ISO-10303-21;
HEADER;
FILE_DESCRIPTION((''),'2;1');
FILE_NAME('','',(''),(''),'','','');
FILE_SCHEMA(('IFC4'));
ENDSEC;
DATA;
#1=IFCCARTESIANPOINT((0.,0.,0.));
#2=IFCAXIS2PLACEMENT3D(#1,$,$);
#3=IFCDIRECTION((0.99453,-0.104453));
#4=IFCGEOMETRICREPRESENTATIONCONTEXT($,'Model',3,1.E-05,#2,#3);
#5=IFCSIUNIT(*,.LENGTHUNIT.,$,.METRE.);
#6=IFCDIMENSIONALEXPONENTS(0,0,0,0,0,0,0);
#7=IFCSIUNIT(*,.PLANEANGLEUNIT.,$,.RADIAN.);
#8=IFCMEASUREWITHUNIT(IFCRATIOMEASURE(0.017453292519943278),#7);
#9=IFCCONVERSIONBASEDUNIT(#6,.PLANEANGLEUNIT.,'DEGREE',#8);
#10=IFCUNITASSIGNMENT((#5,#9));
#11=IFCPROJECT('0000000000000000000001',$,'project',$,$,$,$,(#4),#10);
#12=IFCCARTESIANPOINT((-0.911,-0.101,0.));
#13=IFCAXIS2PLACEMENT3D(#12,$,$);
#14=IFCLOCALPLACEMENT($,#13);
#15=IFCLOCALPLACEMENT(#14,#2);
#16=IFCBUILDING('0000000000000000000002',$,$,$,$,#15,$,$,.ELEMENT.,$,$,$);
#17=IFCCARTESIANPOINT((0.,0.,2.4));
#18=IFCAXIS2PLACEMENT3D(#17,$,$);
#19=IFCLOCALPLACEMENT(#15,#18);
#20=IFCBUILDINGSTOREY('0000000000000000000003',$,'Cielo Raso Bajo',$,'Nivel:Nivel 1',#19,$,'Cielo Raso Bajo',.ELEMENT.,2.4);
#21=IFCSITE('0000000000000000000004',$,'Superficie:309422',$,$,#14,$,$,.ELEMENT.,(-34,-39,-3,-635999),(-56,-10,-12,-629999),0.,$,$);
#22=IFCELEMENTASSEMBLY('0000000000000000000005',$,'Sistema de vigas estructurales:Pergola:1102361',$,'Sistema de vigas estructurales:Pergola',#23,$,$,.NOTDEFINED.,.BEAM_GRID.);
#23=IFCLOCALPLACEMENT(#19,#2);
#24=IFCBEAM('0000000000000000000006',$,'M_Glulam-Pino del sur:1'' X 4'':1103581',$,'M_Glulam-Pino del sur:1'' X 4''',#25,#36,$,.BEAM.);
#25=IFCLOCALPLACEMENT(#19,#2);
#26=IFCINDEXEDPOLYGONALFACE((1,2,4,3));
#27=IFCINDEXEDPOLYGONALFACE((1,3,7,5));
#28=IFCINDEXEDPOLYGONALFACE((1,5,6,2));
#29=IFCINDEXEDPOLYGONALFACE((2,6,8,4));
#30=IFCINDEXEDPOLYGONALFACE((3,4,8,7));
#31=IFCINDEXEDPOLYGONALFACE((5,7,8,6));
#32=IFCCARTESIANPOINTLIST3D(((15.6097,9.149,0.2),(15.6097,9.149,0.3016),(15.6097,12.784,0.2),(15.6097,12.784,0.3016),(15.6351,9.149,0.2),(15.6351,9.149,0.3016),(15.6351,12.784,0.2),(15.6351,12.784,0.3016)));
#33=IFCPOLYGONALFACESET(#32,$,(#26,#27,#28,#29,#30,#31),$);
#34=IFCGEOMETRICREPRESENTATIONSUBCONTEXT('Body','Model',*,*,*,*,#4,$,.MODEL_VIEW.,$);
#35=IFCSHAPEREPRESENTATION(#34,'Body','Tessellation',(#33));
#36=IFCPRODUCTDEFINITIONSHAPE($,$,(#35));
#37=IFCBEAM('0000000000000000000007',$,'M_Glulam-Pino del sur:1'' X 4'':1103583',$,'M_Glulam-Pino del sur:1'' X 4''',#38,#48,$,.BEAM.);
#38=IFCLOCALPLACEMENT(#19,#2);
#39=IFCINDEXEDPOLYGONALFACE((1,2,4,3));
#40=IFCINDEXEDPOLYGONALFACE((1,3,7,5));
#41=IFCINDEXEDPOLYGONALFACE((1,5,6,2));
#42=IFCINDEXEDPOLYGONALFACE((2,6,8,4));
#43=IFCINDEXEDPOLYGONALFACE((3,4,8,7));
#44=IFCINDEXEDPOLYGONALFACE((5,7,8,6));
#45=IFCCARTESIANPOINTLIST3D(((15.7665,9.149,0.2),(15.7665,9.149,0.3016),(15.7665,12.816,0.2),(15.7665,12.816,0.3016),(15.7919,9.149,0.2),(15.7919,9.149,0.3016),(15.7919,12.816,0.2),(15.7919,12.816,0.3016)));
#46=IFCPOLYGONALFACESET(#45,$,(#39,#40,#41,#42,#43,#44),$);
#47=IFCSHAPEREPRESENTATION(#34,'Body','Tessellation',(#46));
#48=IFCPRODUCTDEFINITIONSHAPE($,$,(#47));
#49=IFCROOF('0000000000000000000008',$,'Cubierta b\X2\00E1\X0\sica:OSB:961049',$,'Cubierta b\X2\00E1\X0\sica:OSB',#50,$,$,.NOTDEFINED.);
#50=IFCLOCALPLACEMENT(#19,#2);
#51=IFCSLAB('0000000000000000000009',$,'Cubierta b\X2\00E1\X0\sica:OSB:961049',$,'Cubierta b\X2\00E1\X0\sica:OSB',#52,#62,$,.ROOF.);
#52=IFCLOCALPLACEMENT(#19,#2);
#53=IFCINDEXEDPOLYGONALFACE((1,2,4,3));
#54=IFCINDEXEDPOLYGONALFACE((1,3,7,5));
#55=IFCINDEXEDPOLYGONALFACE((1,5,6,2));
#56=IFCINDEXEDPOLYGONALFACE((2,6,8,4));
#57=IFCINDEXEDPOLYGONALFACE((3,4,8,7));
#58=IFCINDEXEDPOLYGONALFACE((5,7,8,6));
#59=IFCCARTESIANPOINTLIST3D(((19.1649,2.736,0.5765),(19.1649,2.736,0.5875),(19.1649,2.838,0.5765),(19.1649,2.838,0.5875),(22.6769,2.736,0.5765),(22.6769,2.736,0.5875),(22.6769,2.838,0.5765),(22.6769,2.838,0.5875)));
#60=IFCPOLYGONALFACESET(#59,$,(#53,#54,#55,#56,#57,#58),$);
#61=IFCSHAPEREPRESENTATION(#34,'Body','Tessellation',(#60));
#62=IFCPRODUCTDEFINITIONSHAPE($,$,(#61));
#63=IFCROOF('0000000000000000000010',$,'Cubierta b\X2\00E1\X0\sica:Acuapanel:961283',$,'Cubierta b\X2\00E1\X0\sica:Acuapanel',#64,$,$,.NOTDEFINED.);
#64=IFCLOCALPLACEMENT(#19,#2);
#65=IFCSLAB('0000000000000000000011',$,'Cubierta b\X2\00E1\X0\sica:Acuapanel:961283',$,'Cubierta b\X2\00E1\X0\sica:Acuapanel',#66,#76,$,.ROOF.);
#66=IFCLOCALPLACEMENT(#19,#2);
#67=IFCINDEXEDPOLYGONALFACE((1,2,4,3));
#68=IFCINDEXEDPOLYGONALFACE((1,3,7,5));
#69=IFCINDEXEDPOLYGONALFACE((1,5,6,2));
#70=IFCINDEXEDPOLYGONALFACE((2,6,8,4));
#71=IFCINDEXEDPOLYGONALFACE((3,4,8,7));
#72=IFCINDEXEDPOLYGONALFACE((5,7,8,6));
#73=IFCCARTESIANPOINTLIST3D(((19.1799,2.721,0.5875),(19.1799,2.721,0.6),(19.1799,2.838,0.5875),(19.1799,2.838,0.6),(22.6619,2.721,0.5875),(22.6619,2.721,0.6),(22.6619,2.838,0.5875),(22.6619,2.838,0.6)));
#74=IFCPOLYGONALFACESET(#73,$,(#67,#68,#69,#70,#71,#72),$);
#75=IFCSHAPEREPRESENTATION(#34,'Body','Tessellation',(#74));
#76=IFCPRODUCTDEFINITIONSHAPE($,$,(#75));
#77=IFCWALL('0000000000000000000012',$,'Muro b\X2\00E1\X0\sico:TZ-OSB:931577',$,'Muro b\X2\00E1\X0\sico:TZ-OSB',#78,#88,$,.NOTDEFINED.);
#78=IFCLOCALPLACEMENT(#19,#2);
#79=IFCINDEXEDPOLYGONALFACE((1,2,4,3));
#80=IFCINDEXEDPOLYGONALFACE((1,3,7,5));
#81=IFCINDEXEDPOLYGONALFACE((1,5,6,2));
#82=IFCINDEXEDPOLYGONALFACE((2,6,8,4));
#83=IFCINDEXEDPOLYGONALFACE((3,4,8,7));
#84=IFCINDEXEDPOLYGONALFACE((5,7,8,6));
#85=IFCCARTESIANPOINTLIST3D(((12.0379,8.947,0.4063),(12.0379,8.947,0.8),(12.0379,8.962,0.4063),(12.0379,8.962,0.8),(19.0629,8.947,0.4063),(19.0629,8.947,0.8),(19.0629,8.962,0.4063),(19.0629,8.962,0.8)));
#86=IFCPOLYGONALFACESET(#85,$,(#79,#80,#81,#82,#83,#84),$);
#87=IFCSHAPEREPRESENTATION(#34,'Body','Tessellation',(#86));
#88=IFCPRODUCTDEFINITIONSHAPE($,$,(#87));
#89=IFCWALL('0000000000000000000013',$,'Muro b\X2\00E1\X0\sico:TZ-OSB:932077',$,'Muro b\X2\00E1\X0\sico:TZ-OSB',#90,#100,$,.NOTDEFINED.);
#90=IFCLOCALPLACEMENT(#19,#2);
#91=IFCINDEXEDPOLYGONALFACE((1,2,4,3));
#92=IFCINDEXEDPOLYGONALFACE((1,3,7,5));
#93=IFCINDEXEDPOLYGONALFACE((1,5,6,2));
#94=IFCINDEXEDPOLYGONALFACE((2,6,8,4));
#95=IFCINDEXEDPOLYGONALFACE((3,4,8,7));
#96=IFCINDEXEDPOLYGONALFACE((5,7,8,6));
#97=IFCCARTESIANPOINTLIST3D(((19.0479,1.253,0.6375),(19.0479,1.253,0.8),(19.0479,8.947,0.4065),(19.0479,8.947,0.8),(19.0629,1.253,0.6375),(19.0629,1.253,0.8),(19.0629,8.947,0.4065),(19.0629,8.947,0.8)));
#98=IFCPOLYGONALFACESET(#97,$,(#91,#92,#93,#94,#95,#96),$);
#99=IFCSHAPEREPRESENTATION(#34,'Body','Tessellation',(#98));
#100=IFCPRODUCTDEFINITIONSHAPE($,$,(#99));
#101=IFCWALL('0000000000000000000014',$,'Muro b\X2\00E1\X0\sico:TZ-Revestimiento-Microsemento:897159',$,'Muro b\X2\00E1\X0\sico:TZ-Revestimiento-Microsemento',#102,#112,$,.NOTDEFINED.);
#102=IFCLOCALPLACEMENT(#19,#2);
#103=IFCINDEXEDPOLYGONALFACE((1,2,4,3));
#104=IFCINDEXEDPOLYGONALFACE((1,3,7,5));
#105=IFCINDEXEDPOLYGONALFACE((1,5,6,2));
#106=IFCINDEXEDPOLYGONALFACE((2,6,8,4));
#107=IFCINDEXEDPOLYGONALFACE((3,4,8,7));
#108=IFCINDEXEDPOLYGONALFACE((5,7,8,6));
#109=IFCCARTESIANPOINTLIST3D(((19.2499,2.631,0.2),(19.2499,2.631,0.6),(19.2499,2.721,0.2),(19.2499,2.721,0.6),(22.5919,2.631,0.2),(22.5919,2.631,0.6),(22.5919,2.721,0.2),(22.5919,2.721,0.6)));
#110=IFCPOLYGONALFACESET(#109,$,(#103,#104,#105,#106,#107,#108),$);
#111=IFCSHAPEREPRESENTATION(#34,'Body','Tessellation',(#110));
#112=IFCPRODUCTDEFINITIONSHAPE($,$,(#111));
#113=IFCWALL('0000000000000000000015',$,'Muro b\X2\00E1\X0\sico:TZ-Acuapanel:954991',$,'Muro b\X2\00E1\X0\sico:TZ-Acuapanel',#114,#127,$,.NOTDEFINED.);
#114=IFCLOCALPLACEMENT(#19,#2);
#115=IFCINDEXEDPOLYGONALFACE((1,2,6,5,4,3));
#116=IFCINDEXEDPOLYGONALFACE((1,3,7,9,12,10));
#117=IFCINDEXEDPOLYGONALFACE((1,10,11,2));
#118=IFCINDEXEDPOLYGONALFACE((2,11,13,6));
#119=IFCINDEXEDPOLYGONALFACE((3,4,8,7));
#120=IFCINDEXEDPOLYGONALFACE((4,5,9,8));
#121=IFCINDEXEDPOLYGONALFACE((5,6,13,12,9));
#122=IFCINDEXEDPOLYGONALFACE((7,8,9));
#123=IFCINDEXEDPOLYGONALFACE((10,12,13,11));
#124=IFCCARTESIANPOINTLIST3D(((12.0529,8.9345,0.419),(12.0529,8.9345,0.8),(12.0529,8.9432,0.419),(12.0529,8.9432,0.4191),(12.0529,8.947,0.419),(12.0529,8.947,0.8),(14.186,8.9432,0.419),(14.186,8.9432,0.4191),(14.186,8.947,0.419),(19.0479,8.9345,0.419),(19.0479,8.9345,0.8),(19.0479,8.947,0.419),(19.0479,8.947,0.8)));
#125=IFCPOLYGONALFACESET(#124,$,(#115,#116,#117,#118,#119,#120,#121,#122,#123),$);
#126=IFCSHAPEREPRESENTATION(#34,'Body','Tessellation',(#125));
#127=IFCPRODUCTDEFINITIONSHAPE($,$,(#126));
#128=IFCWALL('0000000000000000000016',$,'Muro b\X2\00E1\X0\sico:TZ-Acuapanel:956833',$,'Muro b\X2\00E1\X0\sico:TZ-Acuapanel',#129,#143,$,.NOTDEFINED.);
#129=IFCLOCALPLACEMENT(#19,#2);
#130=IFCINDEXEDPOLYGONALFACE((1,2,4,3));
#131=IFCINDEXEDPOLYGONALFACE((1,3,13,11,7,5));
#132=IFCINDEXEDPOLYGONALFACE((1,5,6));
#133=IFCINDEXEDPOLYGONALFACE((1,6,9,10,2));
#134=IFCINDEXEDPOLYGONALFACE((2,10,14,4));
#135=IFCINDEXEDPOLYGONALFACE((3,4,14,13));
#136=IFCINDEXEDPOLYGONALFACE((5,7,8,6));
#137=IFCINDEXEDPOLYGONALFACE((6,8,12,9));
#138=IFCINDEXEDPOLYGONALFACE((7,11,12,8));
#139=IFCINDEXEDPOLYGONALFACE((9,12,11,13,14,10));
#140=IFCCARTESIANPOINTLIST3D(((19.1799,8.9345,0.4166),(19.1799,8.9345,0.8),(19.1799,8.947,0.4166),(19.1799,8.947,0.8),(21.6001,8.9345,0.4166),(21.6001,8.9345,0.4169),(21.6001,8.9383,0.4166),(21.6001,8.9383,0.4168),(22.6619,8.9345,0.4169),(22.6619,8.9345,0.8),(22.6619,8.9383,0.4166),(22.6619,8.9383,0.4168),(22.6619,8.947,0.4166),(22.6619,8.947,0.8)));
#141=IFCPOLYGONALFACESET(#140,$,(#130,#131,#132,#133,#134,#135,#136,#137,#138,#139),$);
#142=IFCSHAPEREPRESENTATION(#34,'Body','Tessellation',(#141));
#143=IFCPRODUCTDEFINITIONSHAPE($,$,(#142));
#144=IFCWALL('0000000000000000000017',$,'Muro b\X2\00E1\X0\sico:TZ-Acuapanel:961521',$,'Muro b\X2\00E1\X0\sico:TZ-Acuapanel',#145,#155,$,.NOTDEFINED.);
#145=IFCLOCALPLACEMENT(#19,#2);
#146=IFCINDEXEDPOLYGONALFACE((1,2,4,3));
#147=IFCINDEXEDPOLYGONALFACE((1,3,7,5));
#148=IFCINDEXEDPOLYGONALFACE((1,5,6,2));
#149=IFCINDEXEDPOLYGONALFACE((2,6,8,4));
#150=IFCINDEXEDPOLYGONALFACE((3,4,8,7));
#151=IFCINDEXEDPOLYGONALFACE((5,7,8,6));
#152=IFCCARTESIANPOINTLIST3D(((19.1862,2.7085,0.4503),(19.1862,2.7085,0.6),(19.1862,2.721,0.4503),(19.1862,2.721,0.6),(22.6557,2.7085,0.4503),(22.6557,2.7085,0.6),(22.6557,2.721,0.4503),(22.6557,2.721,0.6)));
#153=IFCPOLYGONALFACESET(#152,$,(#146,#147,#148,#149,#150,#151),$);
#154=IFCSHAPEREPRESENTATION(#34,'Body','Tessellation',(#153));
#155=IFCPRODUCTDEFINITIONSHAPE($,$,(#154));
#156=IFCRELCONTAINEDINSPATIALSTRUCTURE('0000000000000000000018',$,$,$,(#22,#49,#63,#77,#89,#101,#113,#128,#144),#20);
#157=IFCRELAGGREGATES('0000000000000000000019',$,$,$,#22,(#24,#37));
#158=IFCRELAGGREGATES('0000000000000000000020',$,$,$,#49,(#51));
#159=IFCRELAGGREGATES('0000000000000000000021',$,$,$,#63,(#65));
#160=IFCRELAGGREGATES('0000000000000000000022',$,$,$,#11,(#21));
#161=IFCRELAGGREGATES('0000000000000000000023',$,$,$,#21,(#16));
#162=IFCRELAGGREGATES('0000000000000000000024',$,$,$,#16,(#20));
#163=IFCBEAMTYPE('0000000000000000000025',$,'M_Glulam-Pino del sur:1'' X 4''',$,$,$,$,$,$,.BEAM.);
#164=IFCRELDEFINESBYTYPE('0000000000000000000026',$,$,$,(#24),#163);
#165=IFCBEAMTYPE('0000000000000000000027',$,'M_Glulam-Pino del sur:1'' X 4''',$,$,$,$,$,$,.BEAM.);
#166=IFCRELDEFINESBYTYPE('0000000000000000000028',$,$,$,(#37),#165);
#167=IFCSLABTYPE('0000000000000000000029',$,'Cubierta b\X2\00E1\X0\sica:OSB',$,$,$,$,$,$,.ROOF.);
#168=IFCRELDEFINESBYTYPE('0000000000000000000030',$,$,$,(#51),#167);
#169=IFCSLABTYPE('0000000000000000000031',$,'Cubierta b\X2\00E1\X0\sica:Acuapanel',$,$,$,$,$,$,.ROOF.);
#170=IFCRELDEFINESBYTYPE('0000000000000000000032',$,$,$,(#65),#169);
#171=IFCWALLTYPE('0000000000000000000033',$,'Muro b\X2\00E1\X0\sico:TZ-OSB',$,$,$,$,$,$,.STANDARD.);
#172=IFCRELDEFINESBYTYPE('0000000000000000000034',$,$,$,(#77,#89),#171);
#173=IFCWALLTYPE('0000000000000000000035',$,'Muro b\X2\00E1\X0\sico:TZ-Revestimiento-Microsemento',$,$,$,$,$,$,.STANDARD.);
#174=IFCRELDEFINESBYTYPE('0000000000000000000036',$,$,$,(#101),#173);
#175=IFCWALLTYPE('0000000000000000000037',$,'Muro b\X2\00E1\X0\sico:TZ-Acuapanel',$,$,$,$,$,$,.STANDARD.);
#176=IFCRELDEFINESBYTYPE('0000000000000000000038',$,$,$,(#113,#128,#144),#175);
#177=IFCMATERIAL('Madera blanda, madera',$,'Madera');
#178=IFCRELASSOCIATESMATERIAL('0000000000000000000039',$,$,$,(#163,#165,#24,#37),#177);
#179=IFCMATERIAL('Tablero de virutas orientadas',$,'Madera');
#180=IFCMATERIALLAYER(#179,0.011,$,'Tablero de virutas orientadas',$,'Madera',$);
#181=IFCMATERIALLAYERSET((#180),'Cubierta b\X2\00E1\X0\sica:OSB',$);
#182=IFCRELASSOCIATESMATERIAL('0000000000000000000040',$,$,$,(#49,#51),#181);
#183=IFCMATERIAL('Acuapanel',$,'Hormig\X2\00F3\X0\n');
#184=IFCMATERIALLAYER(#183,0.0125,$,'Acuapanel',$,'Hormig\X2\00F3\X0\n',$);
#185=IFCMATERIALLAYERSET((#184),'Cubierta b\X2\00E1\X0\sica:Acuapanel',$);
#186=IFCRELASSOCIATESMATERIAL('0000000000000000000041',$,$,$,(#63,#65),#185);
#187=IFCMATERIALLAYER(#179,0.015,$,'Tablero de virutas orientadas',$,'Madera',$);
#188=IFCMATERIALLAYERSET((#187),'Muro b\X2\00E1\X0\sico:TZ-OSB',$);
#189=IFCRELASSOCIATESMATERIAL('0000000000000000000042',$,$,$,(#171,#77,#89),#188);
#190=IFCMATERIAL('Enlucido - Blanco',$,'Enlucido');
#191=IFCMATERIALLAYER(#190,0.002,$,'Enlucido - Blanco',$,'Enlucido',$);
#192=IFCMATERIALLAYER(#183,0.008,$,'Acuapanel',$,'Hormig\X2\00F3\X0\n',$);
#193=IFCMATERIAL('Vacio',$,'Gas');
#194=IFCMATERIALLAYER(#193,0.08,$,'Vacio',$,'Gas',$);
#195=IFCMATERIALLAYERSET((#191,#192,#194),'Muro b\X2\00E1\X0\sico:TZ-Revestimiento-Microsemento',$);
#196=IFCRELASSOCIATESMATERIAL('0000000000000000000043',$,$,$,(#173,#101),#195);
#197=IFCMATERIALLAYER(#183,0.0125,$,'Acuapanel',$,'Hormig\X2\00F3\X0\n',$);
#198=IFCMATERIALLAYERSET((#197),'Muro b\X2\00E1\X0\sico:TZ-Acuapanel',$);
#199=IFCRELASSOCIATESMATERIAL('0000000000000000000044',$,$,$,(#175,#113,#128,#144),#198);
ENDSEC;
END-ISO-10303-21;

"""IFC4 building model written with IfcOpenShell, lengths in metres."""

from ifc_helpers import new_model, entity, si_unit, converted_unit, direction, frame, frame_2d, origin, origin_2d_with_axis, place, context, subcontext, project, spatial, polyline, segment, composite_curve, rectangle, outline, extrude, clip, halfspace, bounded_halfspace, source, transform, mapped, material, layer, layer_set, layer_usage, material_profile, profile_set, profile_usage, type_object, type_shapes, element, aggregate, save


model = new_model("IFC4")

# Units and contexts
model_context = context("Model", 3, precision=1e-05, world=origin(), true_north=direction((0.99453, -0.104453)))
body_context = subcontext(model_context, "Body", "Model", "MODEL_VIEW")
ifc_project = project(units=[si_unit("LENGTHUNIT", "METRE"), converted_unit("PLANEANGLEUNIT", "DEGREE", entity("IfcRatioMeasure", 0.017453292519943278), si_unit("PLANEANGLEUNIT", "RADIAN"), dimensions=[0, 0, 0, 0, 0, 0, 0])], contexts=[model_context])

# Site, building, storey
site_placement = place(None, frame((-0.911, -0.101, 0.0)))
site = spatial("IfcSite", under=ifc_project, at=site_placement, Name="Superficie:309422", CompositionType="ELEMENT", RefLatitude=(-34, -39, -3, -635999), RefLongitude=(-56, -10, -12, -629999), RefElevation=0.0)
building_placement = place(site_placement, origin())
building = spatial("IfcBuilding", under=site, at=building_placement, CompositionType="ELEMENT")
storey_placement = place(building_placement, frame((0.0, 0.0, 2.4)))
storey = spatial("IfcBuildingStorey", under=building, at=storey_placement, Name="Cielo Raso Bajo", ObjectType="Nivel:Nivel 1", LongName="Cielo Raso Bajo", CompositionType="ELEMENT", Elevation=2.4)

# Element assembly, beams
assembly_placement = place(storey_placement, origin())
assembly = element("IfcElementAssembly", 1, at=assembly_placement, inside=storey, Name="Sistema de vigas estructurales:Pergola:1102361", ObjectType="Sistema de vigas estructurales:Pergola", AssemblyPlace="NOTDEFINED", PredefinedType="BEAM_GRID")
ifc_material_1 = material(Name="Madera blanda, madera", Category="Madera")
ifc_material_profile_1 = material_profile(ifc_material_1, outline(composite_curve([segment(polyline([(-0.0127, 0.0508, 0.0), (0.0127, 0.0508, 0.0)]), True, "CONTINUOUS"), segment(polyline([(0.0127, 0.0508, 0.0), (0.0127, -0.0508, 0.0)]), True, "CONTINUOUS"), segment(polyline([(0.0127, -0.0508, 0.0), (-0.0127, -0.0508, 0.0)]), True, "CONTINUOUS"), segment(polyline([(-0.0127, -0.0508, 0.0), (-0.0127, 0.0508, 0.0)]), True, "CONTINUOUS")], self_intersect=False), kind="CURVE"), Name="1' X 4'")
ifc_material_profile_2 = material_profile(ifc_material_1, outline(composite_curve([segment(polyline([(2.5145, -0.0127, -0.0508), (2.5145, -0.0127, 0.0508)]), True, "CONTINUOUS"), segment(polyline([(2.5145, -0.0127, 0.0508), (-2.5145, -0.0127, 0.0508)]), True, "CONTINUOUS"), segment(polyline([(-2.5145, -0.0127, 0.0508), (-2.5145, -0.0127, -0.0508)]), True, "CONTINUOUS"), segment(polyline([(-2.5145, -0.0127, -0.0508), (2.5145, -0.0127, -0.0508)]), True, "CONTINUOUS")], self_intersect=False), kind="CURVE"), Name="1' X 4'")
ifc_profile_set = profile_set([ifc_material_profile_1, ifc_material_profile_2], Name="1' X 4'")
ifc_profile_usage_1 = profile_usage(ifc_profile_set, cardinal=8)
beam_type_1 = type_object("IfcBeamType", Name="M_Glulam-Pino del sur:1' X 4'", PredefinedType="BEAM", material=ifc_profile_set)
shared_shape_1 = source(origin(), body_context, "Body", "SweptSolid", [
    extrude(rectangle(XDim=0.1016, YDim=0.0254, at=origin_2d_with_axis()), frame((-1.7485, 0.0, 0.0), z_axis=(1.0, 0.0, 0.0), x_axis=(0.0, 0.0, -1.0)), (0.0, 0.0, 1.0), 3.635),
])
type_shapes(beam_type_1, [shared_shape_1])
beam_1_placement = place(assembly_placement, frame((15.6224, 10.8975, 0.2508), z_axis=(0.0, 0.0, 1.0), x_axis=(0.0, 1.0, 0.0)))
beam_1 = element("IfcBeam", 2, at=beam_1_placement, type_object=beam_type_1, material=ifc_profile_usage_1, Name="M_Glulam-Pino del sur:1' X 4':1103581", ObjectType="M_Glulam-Pino del sur:1' X 4'", PredefinedType="BEAM", context=body_context, shape_type="MappedRepresentation", body=[
    mapped(shared_shape_1, transform((0.0, 0.0, 0.0), scale=1.0)),
])
ifc_profile_usage_2 = profile_usage(ifc_profile_set, cardinal=8)
beam_type_2 = type_object("IfcBeamType", Name="M_Glulam-Pino del sur:1' X 4'", PredefinedType="BEAM", material=ifc_profile_set)
shared_shape_2 = source(origin(), body_context, "Body", "SweptSolid", [
    extrude(rectangle(XDim=0.1016, YDim=0.0254, at=origin_2d_with_axis()), frame((-1.7485, 0.0, 0.0), z_axis=(1.0, 0.0, 0.0), x_axis=(0.0, 0.0, -1.0)), (0.0, 0.0, 1.0), 3.667),
])
type_shapes(beam_type_2, [shared_shape_2])
beam_2_placement = place(assembly_placement, frame((15.7792, 10.8975, 0.2508), z_axis=(0.0, 0.0, 1.0), x_axis=(0.0, 1.0, 0.0)))
beam_2 = element("IfcBeam", 3, at=beam_2_placement, type_object=beam_type_2, material=ifc_profile_usage_2, Name="M_Glulam-Pino del sur:1' X 4':1103583", ObjectType="M_Glulam-Pino del sur:1' X 4'", PredefinedType="BEAM", context=body_context, shape_type="MappedRepresentation", body=[
    mapped(shared_shape_2, transform((0.0, 0.0, 0.0), scale=1.0)),
])
aggregate(assembly, [beam_1, beam_2])

# Roofs, slabs
ifc_material_2 = material(Name="Tablero de virutas orientadas", Category="Madera")
ifc_layer_1 = layer(ifc_material_2, 0.011, Name="Tablero de virutas orientadas", Category="Madera")
ifc_layer_set_1 = layer_set([ifc_layer_1], Name="Cubierta básica:OSB")
roof_1_placement = place(storey_placement, frame((19.1649, 2.736, 0.5765)))
roof_1 = element("IfcRoof", 4, at=roof_1_placement, inside=storey, material=ifc_layer_set_1, Name="Cubierta básica:OSB:961049", ObjectType="Cubierta básica:OSB", PredefinedType="NOTDEFINED")
slab_type_1 = type_object("IfcSlabType", Name="Cubierta básica:OSB", PredefinedType="ROOF")
slab_1_placement = place(roof_1_placement, origin())
slab_1 = element("IfcSlab", 5, at=slab_1_placement, type_object=slab_type_1, material=ifc_layer_set_1, Name="Cubierta básica:OSB:961049", ObjectType="Cubierta básica:OSB", PredefinedType="ROOF", context=body_context, shape_type="SweptSolid", body=[
    extrude(rectangle(XDim=3.512, YDim=0.102, at=frame_2d((0.0, 0.0), x_axis=(1.0, 0.0))), frame((1.756, 0.051, 0.0)), (0.0, 0.0, 1.0), 0.011),
])
aggregate(roof_1, [slab_1])
ifc_material_3 = material(Name="Acuapanel", Category="Hormigón")
ifc_layer_2 = layer(ifc_material_3, 0.0125, Name="Acuapanel", Category="Hormigón")
ifc_layer_set_2 = layer_set([ifc_layer_2], Name="Cubierta básica:Acuapanel")
roof_2_placement = place(storey_placement, frame((19.1799, 2.721, 0.5875)))
roof_2 = element("IfcRoof", 6, at=roof_2_placement, inside=storey, material=ifc_layer_set_2, Name="Cubierta básica:Acuapanel:961283", ObjectType="Cubierta básica:Acuapanel", PredefinedType="NOTDEFINED")
slab_type_2 = type_object("IfcSlabType", Name="Cubierta básica:Acuapanel", PredefinedType="ROOF")
slab_2_placement = place(roof_2_placement, origin())
slab_2 = element("IfcSlab", 7, at=slab_2_placement, type_object=slab_type_2, material=ifc_layer_set_2, Name="Cubierta básica:Acuapanel:961283", ObjectType="Cubierta básica:Acuapanel", PredefinedType="ROOF", context=body_context, shape_type="SweptSolid", body=[
    extrude(rectangle(XDim=3.482, YDim=0.117, at=frame_2d((0.0, 0.0), x_axis=(1.0, 0.0))), frame((1.741, 0.0585, 0.0)), (0.0, 0.0, 1.0), 0.0125),
])
aggregate(roof_2, [slab_2])

# Walls
ifc_layer_3 = layer(ifc_material_2, 0.015, Name="Tablero de virutas orientadas", Category="Madera")
ifc_layer_set_3 = layer_set([ifc_layer_3], Name="Muro básico:TZ-OSB")
ifc_layer_usage_1 = layer_usage(ifc_layer_set_3, "AXIS2", "NEGATIVE", 0.0075)
wall_type_1 = type_object("IfcWallType", Name="Muro básico:TZ-OSB", PredefinedType="STANDARD", material=ifc_layer_set_3)
wall_1_placement = place(storey_placement, frame((19.0629, 8.9545, 0.4063), z_axis=(0.0, 0.0, 1.0), x_axis=(-1.0, 0.0, 0.0)))
element("IfcWall", 8, at=wall_1_placement, inside=storey, type_object=wall_type_1, material=ifc_layer_usage_1, Name="Muro básico:TZ-OSB:931577", ObjectType="Muro básico:TZ-OSB", PredefinedType="NOTDEFINED", context=body_context, shape_type="SweptSolid", body=[
    extrude(rectangle(XDim=7.025, YDim=0.015, at=frame_2d((3.5125, 0.0), x_axis=(-1.0, 0.0))), origin(), (0.0, 0.0, 1.0), 0.3937),
])
ifc_layer_usage_2 = layer_usage(ifc_layer_set_3, "AXIS2", "NEGATIVE", 0.0075)
wall_2_placement = place(storey_placement, frame((19.0554, 1.253, 0.4065), z_axis=(0.0, 0.0, 1.0), x_axis=(0.0, 1.0, 0.0)))
element("IfcWall", 9, at=wall_2_placement, inside=storey, type_object=wall_type_1, material=ifc_layer_usage_2, Name="Muro básico:TZ-OSB:932077", ObjectType="Muro básico:TZ-OSB", PredefinedType="NOTDEFINED", context=body_context, shape_type="Clipping", body=[
    clip(extrude(rectangle(XDim=7.694, YDim=0.015, at=frame_2d((3.847, 0.0), x_axis=(-1.0, 0.0))), origin(), (0.0, 0.0, 1.0), 0.3935), halfspace(frame((7.694, -0.0075, 0.0), z_axis=(-0.030015, 0.0, -0.999549), x_axis=(0.0, 1.0, 0.0)), False)),
])
ifc_material_4 = material(Name="Enlucido - Blanco", Category="Enlucido")
ifc_layer_4 = layer(ifc_material_4, 0.002, Name="Enlucido - Blanco", Category="Enlucido")
ifc_layer_5 = layer(ifc_material_3, 0.008, Name="Acuapanel", Category="Hormigón")
ifc_material_5 = material(Name="Vacio", Category="Gas")
ifc_layer_6 = layer(ifc_material_5, 0.08, Name="Vacio", Category="Gas")
ifc_layer_set_4 = layer_set([ifc_layer_4, ifc_layer_5, ifc_layer_6], Name="Muro básico:TZ-Revestimiento-Microsemento")
ifc_layer_usage_3 = layer_usage(ifc_layer_set_4, "AXIS2", "NEGATIVE", 0.045)
wall_type_2 = type_object("IfcWallType", Name="Muro básico:TZ-Revestimiento-Microsemento", PredefinedType="STANDARD", material=ifc_layer_set_4)
wall_3_placement = place(storey_placement, frame((22.5919, 2.676, 0.2), z_axis=(0.0, 0.0, 1.0), x_axis=(-1.0, 0.0, 0.0)))
element("IfcWall", 10, at=wall_3_placement, inside=storey, type_object=wall_type_2, material=ifc_layer_usage_3, Name="Muro básico:TZ-Revestimiento-Microsemento:897159", ObjectType="Muro básico:TZ-Revestimiento-Microsemento", PredefinedType="NOTDEFINED", context=body_context, shape_type="SweptSolid", body=[
    extrude(rectangle(XDim=3.342, YDim=0.09, at=frame_2d((1.671, 0.0), x_axis=(-1.0, 0.0))), origin(), (0.0, 0.0, 1.0), 0.4),
])
ifc_layer_7 = layer(ifc_material_3, 0.0125, Name="Acuapanel", Category="Hormigón")
ifc_layer_set_5 = layer_set([ifc_layer_7], Name="Muro básico:TZ-Acuapanel")
ifc_layer_usage_4 = layer_usage(ifc_layer_set_5, "AXIS2", "NEGATIVE", 0.0063)
wall_type_3 = type_object("IfcWallType", Name="Muro básico:TZ-Acuapanel", PredefinedType="STANDARD", material=ifc_layer_set_5)
wall_4_placement = place(storey_placement, frame((19.0479, 8.9408, 0.419), z_axis=(0.0, 0.0, 1.0), x_axis=(-1.0, 0.0, 0.0)))
element("IfcWall", 11, at=wall_4_placement, inside=storey, type_object=wall_type_3, material=ifc_layer_usage_4, Name="Muro básico:TZ-Acuapanel:954991", ObjectType="Muro básico:TZ-Acuapanel", PredefinedType="NOTDEFINED", context=body_context, shape_type="Clipping", body=[
    clip(extrude(rectangle(XDim=6.995, YDim=0.0125, at=frame_2d((3.4975, 0.0), x_axis=(-1.0, 0.0))), origin(), (0.0, 0.0, 1.0), 0.381), bounded_halfspace(frame((6.995, -0.0063, 0.0), z_axis=(0.0, -0.030015, 0.999549), x_axis=(1.0, 0.0, 0.0)), True, frame((6.995, -0.0063, 0.0), z_axis=(0.0, -0.030015, 0.999549), x_axis=(1.0, 0.0, 0.0)), polyline([(0.0, 0.0), (0.0, 0.0038), (-0.0038, 0.0038), (-2.1292, 0.0038), (-2.133, 0.0038), (-2.133, 0.0), (0.0, 0.0)]))),
])
ifc_layer_usage_5 = layer_usage(ifc_layer_set_5, "AXIS2", "POSITIVE", -0.0063)
wall_5_placement = place(storey_placement, frame((19.1799, 8.9408, 0.4166)))
element("IfcWall", 12, at=wall_5_placement, inside=storey, type_object=wall_type_3, material=ifc_layer_usage_5, Name="Muro básico:TZ-Acuapanel:956833", ObjectType="Muro básico:TZ-Acuapanel", PredefinedType="NOTDEFINED", context=body_context, shape_type="Clipping", body=[
    clip(extrude(rectangle(XDim=3.482, YDim=0.0125, at=frame_2d((1.741, 0.0), x_axis=(-1.0, 0.0))), origin(), (0.0, 0.0, 1.0), 0.3834), bounded_halfspace(frame((3.482, -0.0063, 0.0004), z_axis=(0.0, 0.030015, 0.999549), x_axis=(-1.0, 0.0, 0.0)), True, frame((3.482, -0.0063, 0.0004), z_axis=(0.0, 0.030015, 0.999549), x_axis=(-1.0, 0.0, 0.0)), polyline([(0.0, 0.0), (0.0, -0.0038), (1.0618, -0.0038), (1.0618, 0.0), (1.058, 0.0), (0.0038, 0.0), (0.0, 0.0)]))),
])
ifc_layer_usage_6 = layer_usage(ifc_layer_set_5, "AXIS2", "POSITIVE", -0.0063)
wall_6_placement = place(storey_placement, frame((19.1862, 2.7148, 0.4503)))
element("IfcWall", 13, at=wall_6_placement, inside=storey, type_object=wall_type_3, material=ifc_layer_usage_6, Name="Muro básico:TZ-Acuapanel:961521", ObjectType="Muro básico:TZ-Acuapanel", PredefinedType="NOTDEFINED", context=body_context, shape_type="SweptSolid", body=[
    extrude(rectangle(XDim=3.4695, YDim=0.0125, at=frame_2d((1.7348, 0.0), x_axis=(-1.0, 0.0))), origin(), (0.0, 0.0, 1.0), 0.1497),
])

save(model, "model.ifc")
